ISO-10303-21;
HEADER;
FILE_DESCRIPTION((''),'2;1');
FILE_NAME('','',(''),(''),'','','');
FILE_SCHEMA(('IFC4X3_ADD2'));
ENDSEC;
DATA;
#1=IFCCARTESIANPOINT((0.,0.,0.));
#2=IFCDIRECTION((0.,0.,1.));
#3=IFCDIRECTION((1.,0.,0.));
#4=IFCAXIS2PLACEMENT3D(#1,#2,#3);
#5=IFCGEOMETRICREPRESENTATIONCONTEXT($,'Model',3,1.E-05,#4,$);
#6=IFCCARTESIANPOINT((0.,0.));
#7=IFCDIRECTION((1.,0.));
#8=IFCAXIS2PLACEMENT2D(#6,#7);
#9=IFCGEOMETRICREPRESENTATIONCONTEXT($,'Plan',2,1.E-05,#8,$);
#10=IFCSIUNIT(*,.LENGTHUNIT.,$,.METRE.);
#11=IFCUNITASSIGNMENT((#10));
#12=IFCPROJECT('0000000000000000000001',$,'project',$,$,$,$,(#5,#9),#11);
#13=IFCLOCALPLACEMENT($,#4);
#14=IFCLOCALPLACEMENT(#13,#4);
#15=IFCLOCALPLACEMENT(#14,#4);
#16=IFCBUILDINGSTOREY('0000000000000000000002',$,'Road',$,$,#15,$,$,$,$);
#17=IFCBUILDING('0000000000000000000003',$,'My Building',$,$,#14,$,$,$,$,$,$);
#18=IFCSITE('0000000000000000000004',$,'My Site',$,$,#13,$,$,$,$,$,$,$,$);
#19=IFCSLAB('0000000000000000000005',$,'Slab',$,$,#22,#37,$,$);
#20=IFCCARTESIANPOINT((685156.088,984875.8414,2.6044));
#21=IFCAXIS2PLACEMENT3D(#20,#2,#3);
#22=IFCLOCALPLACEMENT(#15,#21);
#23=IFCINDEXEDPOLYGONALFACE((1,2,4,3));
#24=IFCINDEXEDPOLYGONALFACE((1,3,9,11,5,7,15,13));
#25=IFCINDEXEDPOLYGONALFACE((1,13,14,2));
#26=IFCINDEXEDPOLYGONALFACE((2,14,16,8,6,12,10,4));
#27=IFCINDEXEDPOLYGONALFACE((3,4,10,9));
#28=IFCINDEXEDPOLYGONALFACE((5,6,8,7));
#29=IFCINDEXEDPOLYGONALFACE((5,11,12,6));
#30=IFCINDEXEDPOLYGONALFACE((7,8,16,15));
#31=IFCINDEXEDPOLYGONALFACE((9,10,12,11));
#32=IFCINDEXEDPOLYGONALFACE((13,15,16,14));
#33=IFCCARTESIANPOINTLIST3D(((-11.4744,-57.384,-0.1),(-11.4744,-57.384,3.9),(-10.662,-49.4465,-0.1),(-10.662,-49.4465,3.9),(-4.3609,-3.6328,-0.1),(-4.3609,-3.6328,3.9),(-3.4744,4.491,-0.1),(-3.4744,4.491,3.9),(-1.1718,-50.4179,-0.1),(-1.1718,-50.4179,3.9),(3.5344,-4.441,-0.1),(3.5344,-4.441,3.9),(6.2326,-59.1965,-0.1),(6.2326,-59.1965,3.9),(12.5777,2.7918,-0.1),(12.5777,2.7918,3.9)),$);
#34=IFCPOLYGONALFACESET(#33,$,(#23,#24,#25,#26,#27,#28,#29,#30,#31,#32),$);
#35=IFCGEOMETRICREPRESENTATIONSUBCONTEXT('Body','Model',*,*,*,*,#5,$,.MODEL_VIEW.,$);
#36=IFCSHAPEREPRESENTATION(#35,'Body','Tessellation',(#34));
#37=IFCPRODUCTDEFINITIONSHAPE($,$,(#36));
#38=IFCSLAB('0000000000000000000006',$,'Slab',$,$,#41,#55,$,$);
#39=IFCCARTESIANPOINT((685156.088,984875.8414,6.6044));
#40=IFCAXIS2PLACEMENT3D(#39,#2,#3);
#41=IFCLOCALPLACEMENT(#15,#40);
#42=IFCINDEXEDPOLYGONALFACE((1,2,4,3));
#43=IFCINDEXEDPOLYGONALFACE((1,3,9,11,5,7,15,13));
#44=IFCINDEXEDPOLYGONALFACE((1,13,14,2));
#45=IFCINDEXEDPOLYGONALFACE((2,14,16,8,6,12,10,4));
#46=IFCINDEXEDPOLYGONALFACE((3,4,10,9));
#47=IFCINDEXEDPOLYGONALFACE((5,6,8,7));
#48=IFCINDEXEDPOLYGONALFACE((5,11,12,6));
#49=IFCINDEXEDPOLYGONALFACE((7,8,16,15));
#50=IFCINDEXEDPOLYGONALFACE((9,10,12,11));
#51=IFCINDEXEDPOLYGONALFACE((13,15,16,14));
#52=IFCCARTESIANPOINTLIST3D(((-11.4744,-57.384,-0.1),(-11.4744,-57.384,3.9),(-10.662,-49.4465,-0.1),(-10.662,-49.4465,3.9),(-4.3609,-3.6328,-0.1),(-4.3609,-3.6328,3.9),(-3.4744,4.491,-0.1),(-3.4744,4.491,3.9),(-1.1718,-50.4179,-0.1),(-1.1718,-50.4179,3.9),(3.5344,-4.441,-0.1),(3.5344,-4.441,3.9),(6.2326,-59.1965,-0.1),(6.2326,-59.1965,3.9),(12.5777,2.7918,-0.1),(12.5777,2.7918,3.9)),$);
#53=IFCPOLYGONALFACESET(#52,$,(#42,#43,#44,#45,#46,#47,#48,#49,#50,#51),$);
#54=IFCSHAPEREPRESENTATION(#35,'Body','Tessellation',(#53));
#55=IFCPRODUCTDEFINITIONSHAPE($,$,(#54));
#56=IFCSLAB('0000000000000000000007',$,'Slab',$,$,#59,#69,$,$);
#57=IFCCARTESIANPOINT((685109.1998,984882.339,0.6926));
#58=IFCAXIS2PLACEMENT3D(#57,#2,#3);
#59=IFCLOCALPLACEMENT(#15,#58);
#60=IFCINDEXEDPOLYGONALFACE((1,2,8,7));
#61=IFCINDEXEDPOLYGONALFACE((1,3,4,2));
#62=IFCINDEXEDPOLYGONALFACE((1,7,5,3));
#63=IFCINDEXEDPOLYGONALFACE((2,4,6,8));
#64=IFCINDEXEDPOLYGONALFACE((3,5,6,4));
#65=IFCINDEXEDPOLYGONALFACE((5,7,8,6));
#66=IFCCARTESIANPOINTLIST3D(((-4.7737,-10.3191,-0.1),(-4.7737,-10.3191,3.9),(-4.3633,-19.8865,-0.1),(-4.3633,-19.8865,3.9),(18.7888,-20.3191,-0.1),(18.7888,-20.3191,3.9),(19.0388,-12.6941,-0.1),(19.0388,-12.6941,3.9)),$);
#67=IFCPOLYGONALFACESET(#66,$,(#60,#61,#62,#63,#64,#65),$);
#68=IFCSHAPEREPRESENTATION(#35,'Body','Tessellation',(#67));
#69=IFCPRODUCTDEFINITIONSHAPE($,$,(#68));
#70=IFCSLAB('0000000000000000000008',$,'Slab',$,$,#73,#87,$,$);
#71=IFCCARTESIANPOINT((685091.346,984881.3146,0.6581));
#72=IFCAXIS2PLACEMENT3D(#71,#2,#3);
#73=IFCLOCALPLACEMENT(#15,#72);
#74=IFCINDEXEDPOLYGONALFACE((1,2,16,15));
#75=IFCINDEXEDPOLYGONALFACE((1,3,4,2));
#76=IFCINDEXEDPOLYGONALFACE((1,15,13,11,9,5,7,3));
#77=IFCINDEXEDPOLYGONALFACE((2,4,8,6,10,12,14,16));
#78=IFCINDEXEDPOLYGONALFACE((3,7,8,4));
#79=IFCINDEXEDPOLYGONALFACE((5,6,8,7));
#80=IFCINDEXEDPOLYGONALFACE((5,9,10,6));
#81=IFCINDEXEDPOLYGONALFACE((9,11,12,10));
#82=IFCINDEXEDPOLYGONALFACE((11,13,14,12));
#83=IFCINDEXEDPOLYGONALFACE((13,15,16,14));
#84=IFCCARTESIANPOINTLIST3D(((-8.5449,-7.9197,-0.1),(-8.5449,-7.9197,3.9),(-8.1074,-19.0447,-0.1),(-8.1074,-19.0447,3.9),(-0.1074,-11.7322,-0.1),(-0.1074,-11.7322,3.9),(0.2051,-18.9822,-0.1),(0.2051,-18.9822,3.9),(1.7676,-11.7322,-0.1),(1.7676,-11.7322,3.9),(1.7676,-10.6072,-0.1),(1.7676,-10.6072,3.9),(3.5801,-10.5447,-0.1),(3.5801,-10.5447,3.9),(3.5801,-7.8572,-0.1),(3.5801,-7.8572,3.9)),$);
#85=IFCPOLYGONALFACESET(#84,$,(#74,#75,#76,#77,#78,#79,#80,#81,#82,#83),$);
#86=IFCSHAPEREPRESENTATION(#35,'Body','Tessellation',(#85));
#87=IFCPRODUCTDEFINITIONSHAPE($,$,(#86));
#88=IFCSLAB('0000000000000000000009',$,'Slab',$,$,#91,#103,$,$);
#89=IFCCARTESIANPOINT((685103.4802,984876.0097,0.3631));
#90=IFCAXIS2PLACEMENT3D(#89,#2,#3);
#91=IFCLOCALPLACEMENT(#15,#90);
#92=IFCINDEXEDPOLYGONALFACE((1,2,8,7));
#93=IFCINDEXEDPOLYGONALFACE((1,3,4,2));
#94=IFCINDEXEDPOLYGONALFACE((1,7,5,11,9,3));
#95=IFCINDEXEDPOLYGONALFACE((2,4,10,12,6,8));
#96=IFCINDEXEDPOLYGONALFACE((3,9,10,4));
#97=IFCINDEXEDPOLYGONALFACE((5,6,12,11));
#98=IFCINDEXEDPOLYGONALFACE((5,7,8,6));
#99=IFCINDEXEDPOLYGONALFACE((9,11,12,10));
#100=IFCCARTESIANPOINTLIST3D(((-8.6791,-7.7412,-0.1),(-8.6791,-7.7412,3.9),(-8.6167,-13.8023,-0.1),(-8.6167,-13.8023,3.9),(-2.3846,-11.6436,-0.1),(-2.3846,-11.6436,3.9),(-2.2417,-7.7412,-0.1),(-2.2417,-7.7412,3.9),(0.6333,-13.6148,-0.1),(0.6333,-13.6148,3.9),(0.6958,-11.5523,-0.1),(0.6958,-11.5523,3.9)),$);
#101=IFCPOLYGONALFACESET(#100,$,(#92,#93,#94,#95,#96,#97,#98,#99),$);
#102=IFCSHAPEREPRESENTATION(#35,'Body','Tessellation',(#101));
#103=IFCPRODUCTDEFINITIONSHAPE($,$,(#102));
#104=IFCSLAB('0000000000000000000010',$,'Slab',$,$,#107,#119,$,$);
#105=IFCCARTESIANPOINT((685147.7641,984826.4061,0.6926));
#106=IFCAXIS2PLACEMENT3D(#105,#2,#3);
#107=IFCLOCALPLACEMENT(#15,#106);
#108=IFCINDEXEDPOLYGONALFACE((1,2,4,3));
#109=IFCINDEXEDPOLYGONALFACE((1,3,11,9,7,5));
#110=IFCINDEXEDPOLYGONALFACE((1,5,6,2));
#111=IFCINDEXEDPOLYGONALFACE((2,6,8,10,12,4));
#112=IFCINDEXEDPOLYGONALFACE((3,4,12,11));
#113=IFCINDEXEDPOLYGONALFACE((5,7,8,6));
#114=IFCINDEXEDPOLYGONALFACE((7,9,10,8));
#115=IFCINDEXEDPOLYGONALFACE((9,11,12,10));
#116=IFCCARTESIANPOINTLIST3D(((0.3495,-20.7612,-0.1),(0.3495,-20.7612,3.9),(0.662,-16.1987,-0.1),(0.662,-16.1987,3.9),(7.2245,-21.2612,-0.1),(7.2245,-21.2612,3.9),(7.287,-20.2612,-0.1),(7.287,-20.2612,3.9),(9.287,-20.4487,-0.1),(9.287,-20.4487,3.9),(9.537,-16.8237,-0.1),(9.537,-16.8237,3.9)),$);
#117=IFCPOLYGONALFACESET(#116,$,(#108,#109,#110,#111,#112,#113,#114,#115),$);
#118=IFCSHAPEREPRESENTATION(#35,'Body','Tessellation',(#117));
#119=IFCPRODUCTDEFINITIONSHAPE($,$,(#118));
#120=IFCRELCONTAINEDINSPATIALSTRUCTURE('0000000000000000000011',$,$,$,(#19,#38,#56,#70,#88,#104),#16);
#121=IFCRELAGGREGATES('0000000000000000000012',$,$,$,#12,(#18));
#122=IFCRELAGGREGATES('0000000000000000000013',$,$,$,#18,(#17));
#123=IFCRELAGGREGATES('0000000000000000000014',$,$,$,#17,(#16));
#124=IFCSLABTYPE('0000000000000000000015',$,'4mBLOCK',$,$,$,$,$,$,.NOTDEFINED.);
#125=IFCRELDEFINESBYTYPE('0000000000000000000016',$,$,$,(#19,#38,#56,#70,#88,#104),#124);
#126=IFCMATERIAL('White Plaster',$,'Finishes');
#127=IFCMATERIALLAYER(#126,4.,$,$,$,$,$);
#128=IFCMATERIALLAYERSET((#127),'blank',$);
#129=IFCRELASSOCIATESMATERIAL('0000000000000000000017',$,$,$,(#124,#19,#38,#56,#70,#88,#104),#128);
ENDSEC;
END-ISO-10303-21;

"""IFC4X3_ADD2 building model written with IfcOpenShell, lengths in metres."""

from ifc_helpers import new_model, si_unit, frame, origin_with_axes, origin_2d_with_axis, place, context, subcontext, project, spatial, indexed_curve, outline, extrude, material, layer, layer_set, layer_usage, type_object, element, save


model = new_model("IFC4X3_ADD2")

# Units and contexts
model_context = context("Model", 3, precision=1e-05, world=origin_with_axes())
plan_context = context("Plan", 2, precision=1e-05, world=origin_2d_with_axis())
body_context = subcontext(model_context, "Body", "Model", "MODEL_VIEW")
ifc_project = project(units=[si_unit("LENGTHUNIT", "METRE")], contexts=[model_context, plan_context])

# Site, building, storey
site_placement = place(None, origin_with_axes())
site = spatial("IfcSite", under=ifc_project, at=site_placement, Name="My Site")
building_placement = place(site_placement, origin_with_axes())
building = spatial("IfcBuilding", under=site, at=building_placement, Name="My Building")
storey_placement = place(building_placement, origin_with_axes())
storey = spatial("IfcBuildingStorey", under=building, at=storey_placement, Name="Road")

# Slabs
ifc_material = material(Name="White Plaster", Category="Finishes")
ifc_layer = layer(ifc_material, 4.0)
ifc_layer_set = layer_set([ifc_layer], Name="blank")
ifc_layer_usage_1 = layer_usage(ifc_layer_set, "AXIS3", "POSITIVE", -0.1)
slab_type = type_object("IfcSlabType", Name="4mBLOCK", PredefinedType="NOTDEFINED", material=ifc_layer_set)
slab_1_placement = place(storey_placement, frame((685156.088, 984875.8414, 2.6044), z_axis=(0.0, 0.0, 1.0), x_axis=(1.0, 0.0, 0.0)))
element("IfcSlab", 1, at=slab_1_placement, inside=storey, type_object=slab_type, material=ifc_layer_usage_1, Name="Slab", context=body_context, shape_type="SweptSolid", body=[
    extrude(outline(indexed_curve([(-4.3609, -3.6328), (3.5344, -4.441), (-1.1718, -50.4179), (-10.662, -49.4465), (-11.4744, -57.384), (6.2326, -59.1965), (12.5777, 2.7918), (-3.4744, 4.491), (-4.3609, -3.6328)])), frame((0.0, 0.0, -0.1), z_axis=(0.0, 0.0, 1.0), x_axis=(1.0, 0.0, 0.0)), (0.0, 0.0, 1.0), 4.0),
])
ifc_layer_usage_2 = layer_usage(ifc_layer_set, "AXIS3", "POSITIVE", -0.1)
slab_2_placement = place(storey_placement, frame((685156.088, 984875.8414, 6.6044), z_axis=(0.0, 0.0, 1.0), x_axis=(1.0, 0.0, 0.0)))
element("IfcSlab", 2, at=slab_2_placement, inside=storey, type_object=slab_type, material=ifc_layer_usage_2, Name="Slab", context=body_context, shape_type="SweptSolid", body=[
    extrude(outline(indexed_curve([(-4.3609, -3.6328), (3.5344, -4.441), (-1.1718, -50.4179), (-10.662, -49.4465), (-11.4744, -57.384), (6.2326, -59.1965), (12.5777, 2.7918), (-3.4744, 4.491), (-4.3609, -3.6328)])), frame((0.0, 0.0, -0.1), z_axis=(0.0, 0.0, 1.0), x_axis=(1.0, 0.0, 0.0)), (0.0, 0.0, 1.0), 4.0),
])
ifc_layer_usage_3 = layer_usage(ifc_layer_set, "AXIS3", "POSITIVE", -0.1)
slab_3_placement = place(storey_placement, frame((685109.1998, 984882.339, 0.6926), z_axis=(0.0, 0.0, 1.0), x_axis=(1.0, 0.0, 0.0)))
element("IfcSlab", 3, at=slab_3_placement, inside=storey, type_object=slab_type, material=ifc_layer_usage_3, Name="Slab", context=body_context, shape_type="SweptSolid", body=[
    extrude(outline(indexed_curve([(-4.7737, -10.3191), (19.0388, -12.6941), (18.7888, -20.3191), (-4.3633, -19.8865), (-4.7737, -10.3191)])), frame((0.0, 0.0, -0.1), z_axis=(0.0, 0.0, 1.0), x_axis=(1.0, 0.0, 0.0)), (0.0, 0.0, 1.0), 4.0),
])
ifc_layer_usage_4 = layer_usage(ifc_layer_set, "AXIS3", "POSITIVE", -0.1)
slab_4_placement = place(storey_placement, frame((685091.346, 984881.3146, 0.6581), z_axis=(0.0, 0.0, 1.0), x_axis=(1.0, 0.0, 0.0)))
element("IfcSlab", 4, at=slab_4_placement, inside=storey, type_object=slab_type, material=ifc_layer_usage_4, Name="Slab", context=body_context, shape_type="SweptSolid", body=[
    extrude(outline(indexed_curve([(-0.1074, -11.7322), (1.7676, -11.7322), (1.7676, -10.6072), (3.5801, -10.5447), (3.5801, -7.8572), (-8.5449, -7.9197), (-8.1074, -19.0447), (0.2051, -18.9822), (-0.1074, -11.7322)])), frame((0.0, 0.0, -0.1), z_axis=(0.0, 0.0, 1.0), x_axis=(1.0, 0.0, 0.0)), (0.0, 0.0, 1.0), 4.0),
])
ifc_layer_usage_5 = layer_usage(ifc_layer_set, "AXIS3", "POSITIVE", -0.1)
slab_5_placement = place(storey_placement, frame((685103.4802, 984876.0097, 0.3631), z_axis=(0.0, 0.0, 1.0), x_axis=(1.0, 0.0, 0.0)))
element("IfcSlab", 5, at=slab_5_placement, inside=storey, type_object=slab_type, material=ifc_layer_usage_5, Name="Slab", context=body_context, shape_type="SweptSolid", body=[
    extrude(outline(indexed_curve([(-2.2417, -7.7412), (-2.3846, -11.6436), (0.6958, -11.5523), (0.6333, -13.6148), (-8.6167, -13.8023), (-8.6791, -7.7412), (-2.2417, -7.7412)])), frame((0.0, 0.0, -0.1), z_axis=(0.0, 0.0, 1.0), x_axis=(1.0, 0.0, 0.0)), (0.0, 0.0, 1.0), 4.0),
])
ifc_layer_usage_6 = layer_usage(ifc_layer_set, "AXIS3", "POSITIVE", -0.1)
slab_6_placement = place(storey_placement, frame((685147.7641, 984826.4061, 0.6926), z_axis=(0.0, 0.0, 1.0), x_axis=(1.0, 0.0, 0.0)))
element("IfcSlab", 6, at=slab_6_placement, inside=storey, type_object=slab_type, material=ifc_layer_usage_6, Name="Slab", context=body_context, shape_type="SweptSolid", body=[
    extrude(outline(indexed_curve([(7.287, -20.2612), (9.287, -20.4487), (9.537, -16.8237), (0.662, -16.1987), (0.3495, -20.7612), (7.2245, -21.2612), (7.287, -20.2612)])), frame((0.0, 0.0, -0.1), z_axis=(0.0, 0.0, 1.0), x_axis=(1.0, 0.0, 0.0)), (0.0, 0.0, 1.0), 4.0),
])

save(model, "model.ifc")
